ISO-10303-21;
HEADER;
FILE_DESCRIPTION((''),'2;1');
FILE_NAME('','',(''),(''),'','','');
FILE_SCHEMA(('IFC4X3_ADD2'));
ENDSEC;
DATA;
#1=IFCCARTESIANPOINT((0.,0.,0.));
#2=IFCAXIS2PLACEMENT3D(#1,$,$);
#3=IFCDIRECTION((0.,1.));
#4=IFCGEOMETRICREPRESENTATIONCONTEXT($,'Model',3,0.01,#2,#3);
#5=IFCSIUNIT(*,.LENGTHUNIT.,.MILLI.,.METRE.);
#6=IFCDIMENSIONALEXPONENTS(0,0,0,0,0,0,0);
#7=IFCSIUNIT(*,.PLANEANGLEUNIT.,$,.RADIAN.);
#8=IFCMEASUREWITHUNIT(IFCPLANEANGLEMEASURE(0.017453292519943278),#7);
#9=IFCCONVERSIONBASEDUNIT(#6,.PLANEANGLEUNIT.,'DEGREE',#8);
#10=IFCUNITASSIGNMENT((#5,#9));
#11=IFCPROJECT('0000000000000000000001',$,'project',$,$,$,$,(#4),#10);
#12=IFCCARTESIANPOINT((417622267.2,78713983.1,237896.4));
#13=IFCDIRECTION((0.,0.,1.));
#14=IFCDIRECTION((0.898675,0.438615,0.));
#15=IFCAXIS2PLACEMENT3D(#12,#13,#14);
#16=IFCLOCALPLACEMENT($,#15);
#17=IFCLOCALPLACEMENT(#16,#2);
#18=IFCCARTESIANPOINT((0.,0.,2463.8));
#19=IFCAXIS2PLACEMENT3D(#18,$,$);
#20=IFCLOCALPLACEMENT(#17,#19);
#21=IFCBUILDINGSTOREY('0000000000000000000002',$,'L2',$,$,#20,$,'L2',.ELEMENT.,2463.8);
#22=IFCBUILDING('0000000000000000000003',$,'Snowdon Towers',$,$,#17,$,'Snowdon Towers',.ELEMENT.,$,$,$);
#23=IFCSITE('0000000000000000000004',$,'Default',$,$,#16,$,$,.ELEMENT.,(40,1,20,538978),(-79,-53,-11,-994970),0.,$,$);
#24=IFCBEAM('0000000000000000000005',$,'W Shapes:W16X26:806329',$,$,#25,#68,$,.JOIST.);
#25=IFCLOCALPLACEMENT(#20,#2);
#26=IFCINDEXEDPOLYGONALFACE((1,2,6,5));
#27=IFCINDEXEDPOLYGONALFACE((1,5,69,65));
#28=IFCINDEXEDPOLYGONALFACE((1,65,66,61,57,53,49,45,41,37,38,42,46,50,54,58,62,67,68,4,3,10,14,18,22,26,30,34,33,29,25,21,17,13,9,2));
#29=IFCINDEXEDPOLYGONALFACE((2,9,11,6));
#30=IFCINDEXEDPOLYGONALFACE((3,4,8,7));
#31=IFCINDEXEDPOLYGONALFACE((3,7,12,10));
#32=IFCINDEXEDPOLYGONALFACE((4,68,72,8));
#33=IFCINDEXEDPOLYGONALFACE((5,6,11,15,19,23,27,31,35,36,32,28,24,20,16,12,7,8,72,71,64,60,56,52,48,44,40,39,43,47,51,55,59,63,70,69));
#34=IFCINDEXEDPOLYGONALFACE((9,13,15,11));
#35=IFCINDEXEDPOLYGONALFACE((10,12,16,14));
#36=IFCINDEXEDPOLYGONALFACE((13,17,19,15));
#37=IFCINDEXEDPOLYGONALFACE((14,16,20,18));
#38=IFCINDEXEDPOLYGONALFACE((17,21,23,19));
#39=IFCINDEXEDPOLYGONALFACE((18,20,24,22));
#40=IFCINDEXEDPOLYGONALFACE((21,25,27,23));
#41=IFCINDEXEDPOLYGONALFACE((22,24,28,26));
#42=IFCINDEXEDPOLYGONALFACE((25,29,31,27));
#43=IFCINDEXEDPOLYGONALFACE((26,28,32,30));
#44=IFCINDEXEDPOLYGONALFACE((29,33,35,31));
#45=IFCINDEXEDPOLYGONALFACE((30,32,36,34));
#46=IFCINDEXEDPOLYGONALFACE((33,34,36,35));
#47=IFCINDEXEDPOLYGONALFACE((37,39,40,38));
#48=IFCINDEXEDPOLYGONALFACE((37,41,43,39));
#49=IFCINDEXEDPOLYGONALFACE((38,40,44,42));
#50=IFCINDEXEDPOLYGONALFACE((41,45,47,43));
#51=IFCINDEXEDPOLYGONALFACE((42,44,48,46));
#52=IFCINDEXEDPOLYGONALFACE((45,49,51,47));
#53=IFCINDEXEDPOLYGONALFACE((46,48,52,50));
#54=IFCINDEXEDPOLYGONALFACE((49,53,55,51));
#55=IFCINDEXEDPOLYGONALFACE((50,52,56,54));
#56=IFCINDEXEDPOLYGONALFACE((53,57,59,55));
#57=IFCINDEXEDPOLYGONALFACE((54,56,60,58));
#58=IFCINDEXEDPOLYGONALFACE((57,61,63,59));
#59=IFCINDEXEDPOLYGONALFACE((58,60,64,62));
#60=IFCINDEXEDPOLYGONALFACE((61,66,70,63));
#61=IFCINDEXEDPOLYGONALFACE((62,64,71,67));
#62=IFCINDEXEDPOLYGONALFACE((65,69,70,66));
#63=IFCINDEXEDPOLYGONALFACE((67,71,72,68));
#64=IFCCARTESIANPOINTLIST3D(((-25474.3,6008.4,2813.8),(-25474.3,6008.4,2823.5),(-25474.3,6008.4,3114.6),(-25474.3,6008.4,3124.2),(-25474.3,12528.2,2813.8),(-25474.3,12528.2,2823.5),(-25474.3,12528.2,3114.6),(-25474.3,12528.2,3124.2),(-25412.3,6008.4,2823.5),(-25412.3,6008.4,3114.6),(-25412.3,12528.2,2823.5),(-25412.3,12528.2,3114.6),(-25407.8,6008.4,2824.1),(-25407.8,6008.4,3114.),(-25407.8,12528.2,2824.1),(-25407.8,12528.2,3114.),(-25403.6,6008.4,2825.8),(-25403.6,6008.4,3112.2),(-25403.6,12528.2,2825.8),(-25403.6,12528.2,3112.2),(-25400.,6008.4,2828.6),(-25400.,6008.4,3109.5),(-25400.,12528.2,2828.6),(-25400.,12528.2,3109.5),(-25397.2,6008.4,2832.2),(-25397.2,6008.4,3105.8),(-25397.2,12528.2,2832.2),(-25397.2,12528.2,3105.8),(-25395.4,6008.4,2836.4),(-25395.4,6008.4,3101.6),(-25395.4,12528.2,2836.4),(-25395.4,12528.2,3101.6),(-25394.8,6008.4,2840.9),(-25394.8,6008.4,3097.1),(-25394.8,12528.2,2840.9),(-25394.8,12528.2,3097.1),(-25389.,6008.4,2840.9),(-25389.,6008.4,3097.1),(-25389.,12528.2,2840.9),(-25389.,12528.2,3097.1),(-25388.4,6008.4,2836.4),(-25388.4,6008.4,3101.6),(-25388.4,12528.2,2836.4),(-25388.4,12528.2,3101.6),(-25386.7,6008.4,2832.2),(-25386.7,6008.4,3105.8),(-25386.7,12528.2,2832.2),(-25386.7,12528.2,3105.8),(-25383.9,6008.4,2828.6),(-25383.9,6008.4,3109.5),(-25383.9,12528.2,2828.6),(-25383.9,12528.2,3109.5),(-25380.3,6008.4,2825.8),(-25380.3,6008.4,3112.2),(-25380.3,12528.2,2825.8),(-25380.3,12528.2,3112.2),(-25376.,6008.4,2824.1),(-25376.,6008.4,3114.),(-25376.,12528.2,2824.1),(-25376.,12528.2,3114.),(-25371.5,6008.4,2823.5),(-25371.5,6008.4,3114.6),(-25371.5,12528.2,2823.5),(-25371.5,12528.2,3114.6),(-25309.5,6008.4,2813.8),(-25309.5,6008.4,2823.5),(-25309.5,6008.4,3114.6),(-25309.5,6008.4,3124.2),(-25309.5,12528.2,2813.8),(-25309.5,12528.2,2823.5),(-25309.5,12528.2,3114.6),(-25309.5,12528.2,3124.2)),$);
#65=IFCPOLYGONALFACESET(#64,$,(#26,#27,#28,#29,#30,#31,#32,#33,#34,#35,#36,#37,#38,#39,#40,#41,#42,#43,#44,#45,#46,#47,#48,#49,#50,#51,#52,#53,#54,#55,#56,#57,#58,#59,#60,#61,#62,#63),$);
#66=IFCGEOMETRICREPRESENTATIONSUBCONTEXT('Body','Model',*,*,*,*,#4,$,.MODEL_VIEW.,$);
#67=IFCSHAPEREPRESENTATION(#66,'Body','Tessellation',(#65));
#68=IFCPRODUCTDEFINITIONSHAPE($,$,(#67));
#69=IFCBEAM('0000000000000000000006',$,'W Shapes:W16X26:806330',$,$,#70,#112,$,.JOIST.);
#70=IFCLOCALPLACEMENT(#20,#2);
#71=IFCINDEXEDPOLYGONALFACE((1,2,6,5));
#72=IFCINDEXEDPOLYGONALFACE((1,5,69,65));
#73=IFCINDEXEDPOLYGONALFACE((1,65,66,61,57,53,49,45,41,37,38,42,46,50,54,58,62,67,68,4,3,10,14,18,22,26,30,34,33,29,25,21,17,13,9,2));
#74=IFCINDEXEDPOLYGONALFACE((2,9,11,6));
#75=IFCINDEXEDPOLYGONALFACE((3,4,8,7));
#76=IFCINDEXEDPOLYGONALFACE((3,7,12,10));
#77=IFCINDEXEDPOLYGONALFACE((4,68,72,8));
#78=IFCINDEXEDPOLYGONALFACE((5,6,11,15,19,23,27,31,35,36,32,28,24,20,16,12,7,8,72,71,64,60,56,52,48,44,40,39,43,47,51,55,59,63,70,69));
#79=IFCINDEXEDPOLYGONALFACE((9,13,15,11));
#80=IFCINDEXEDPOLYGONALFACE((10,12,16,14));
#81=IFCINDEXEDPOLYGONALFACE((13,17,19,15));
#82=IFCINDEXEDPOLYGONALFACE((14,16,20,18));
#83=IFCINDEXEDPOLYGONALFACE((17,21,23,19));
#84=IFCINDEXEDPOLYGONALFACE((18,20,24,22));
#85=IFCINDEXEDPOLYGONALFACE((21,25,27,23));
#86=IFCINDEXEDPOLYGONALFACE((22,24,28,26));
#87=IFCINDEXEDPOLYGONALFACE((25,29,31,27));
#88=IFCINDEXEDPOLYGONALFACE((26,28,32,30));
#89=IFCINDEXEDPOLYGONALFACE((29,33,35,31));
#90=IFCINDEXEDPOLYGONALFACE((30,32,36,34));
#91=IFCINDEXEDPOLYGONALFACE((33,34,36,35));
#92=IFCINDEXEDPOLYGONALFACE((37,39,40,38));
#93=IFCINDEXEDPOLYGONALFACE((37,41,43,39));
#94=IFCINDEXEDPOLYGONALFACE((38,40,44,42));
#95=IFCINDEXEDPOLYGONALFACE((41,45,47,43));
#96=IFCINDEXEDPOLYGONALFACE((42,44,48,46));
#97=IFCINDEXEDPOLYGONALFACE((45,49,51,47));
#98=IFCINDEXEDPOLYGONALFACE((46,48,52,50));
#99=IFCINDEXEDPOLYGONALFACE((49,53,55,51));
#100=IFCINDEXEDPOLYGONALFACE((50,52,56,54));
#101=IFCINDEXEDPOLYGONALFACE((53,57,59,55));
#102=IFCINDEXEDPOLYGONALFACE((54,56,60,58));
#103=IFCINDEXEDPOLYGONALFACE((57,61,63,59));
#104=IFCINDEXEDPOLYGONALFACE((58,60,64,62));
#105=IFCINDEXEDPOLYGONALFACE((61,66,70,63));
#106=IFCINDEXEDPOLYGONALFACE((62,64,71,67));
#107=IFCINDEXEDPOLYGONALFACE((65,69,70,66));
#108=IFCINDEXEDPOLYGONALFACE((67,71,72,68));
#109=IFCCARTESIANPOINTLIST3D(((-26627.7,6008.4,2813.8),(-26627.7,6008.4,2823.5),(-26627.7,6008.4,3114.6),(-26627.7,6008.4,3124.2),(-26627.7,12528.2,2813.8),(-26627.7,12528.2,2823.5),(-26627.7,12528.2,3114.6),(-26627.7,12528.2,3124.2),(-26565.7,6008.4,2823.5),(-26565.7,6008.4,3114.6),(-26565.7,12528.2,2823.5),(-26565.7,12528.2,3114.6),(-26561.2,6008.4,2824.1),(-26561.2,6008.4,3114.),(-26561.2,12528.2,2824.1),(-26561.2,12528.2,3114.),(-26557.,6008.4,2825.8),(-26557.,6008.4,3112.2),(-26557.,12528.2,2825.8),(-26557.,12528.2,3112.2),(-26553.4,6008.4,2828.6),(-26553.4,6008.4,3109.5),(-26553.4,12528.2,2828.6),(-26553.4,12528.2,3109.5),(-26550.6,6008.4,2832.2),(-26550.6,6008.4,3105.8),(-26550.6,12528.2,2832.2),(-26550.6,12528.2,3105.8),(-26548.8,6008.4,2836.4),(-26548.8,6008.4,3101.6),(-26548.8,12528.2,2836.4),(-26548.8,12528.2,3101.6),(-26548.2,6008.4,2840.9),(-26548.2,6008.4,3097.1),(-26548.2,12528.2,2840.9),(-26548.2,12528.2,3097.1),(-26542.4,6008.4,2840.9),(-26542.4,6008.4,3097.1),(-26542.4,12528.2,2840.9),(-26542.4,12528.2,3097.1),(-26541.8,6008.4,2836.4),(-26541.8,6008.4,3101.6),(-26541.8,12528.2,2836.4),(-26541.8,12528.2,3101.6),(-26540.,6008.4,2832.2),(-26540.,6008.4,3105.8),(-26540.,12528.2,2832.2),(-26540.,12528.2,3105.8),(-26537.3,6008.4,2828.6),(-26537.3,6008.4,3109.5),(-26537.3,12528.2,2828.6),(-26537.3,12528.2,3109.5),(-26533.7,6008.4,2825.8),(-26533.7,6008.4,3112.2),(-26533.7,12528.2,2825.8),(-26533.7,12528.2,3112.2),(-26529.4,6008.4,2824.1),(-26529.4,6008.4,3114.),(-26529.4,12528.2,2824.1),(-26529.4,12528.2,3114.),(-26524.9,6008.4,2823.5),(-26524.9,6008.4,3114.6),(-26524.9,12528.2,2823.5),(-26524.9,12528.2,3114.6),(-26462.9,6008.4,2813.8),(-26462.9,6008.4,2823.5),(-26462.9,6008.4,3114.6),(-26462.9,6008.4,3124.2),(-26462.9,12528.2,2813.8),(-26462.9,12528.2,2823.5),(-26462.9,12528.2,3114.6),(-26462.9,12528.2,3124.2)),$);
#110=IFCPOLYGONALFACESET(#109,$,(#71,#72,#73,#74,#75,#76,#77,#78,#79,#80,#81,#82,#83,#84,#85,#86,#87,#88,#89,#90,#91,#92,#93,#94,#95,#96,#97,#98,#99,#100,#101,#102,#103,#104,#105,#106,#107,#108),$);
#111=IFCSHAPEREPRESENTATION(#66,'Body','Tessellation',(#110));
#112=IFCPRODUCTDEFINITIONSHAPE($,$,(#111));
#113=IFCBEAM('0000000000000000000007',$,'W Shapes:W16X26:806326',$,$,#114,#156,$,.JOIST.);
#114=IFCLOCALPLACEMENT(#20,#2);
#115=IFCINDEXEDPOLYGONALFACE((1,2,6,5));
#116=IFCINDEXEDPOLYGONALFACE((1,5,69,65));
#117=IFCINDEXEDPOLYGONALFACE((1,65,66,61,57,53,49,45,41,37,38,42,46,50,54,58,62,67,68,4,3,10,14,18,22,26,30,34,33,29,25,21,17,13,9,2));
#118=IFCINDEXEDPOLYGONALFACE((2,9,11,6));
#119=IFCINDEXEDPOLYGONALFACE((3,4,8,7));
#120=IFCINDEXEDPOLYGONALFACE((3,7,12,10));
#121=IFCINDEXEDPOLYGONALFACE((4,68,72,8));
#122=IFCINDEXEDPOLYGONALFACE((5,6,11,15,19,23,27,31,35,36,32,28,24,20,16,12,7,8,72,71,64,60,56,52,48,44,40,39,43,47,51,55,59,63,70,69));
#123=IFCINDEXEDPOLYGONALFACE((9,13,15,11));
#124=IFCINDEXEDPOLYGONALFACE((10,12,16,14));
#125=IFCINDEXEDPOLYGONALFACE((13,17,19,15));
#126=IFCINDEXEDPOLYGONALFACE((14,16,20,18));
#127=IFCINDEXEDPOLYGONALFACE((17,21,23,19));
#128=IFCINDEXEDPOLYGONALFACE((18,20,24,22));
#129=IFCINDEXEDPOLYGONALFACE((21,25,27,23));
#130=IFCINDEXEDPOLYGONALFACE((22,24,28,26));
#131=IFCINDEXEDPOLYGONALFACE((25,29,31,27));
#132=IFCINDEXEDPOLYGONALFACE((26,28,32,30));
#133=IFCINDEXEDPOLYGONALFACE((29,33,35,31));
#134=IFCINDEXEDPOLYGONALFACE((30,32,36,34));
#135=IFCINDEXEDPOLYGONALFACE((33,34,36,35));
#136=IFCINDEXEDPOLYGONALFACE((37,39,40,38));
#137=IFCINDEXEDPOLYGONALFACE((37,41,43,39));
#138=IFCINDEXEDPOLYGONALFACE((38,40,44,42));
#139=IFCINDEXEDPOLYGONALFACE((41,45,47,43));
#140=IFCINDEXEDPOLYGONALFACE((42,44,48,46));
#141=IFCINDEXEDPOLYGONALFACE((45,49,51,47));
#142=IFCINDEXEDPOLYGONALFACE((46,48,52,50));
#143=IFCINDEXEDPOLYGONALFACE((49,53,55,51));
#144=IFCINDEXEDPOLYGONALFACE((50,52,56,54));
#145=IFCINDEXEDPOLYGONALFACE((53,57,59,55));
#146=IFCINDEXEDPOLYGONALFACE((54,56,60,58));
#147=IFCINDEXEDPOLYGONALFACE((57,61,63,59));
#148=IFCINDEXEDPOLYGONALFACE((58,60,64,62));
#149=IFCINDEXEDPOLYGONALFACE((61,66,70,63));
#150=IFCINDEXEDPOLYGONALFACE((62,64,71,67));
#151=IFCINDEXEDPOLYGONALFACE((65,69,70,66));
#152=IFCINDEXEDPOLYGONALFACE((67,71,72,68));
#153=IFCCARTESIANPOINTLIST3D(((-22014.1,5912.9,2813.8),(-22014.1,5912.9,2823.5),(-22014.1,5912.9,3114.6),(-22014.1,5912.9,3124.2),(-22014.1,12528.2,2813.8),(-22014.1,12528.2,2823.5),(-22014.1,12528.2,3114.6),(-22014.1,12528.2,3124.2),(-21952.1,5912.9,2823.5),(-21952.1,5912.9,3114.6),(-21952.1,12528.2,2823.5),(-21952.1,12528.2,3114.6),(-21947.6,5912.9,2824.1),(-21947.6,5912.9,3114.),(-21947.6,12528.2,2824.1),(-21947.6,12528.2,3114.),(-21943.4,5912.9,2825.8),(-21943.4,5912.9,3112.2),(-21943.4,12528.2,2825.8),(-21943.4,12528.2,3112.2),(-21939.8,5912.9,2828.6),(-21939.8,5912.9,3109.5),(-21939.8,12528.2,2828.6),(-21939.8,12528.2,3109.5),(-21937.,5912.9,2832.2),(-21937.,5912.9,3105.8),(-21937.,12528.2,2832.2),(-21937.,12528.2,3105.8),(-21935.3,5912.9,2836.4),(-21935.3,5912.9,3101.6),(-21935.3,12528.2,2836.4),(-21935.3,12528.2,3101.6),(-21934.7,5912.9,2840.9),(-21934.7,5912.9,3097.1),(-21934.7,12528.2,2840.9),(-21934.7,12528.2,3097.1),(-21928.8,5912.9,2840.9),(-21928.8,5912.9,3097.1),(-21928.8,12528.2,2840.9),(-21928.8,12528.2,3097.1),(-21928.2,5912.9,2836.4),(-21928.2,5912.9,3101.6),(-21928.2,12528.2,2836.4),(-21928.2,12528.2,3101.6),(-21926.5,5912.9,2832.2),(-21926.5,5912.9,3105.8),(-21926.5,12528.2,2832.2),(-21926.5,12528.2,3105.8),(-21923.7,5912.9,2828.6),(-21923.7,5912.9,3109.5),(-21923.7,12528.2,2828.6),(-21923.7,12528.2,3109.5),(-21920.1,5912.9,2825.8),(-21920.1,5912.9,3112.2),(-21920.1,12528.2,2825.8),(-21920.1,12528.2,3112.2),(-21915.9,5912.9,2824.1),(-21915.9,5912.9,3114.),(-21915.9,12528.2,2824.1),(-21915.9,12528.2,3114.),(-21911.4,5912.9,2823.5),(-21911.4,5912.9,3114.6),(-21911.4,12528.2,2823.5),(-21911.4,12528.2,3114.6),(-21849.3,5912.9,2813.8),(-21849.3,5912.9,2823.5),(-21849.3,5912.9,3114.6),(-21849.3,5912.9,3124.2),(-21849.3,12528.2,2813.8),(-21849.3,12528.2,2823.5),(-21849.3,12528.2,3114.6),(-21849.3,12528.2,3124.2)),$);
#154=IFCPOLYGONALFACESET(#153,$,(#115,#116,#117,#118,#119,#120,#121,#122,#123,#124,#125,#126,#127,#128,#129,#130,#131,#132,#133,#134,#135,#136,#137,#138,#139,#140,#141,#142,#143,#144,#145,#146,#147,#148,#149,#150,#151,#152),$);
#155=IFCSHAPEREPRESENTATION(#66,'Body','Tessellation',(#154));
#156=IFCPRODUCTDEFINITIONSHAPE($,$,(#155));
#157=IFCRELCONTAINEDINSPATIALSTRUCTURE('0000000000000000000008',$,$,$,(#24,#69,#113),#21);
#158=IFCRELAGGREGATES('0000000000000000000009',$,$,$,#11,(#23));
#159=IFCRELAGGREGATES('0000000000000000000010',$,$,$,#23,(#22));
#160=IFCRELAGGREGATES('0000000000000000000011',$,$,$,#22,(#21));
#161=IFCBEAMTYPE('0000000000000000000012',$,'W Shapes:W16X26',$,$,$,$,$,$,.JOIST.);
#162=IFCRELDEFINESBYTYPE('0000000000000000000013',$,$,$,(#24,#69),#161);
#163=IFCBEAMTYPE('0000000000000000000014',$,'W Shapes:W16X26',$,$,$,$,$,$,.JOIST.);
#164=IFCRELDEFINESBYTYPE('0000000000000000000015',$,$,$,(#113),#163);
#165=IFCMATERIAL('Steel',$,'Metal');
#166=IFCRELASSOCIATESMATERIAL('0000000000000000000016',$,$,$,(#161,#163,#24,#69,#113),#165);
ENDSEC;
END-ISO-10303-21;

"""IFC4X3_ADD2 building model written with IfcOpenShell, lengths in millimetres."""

from ifc_helpers import new_model, entity, si_unit, converted_unit, direction, frame, frame_2d, origin, place, context, subcontext, project, spatial, polyline, circle_curve, parameter, trimmed, segment, composite_curve, outline, extrude, source, transform, mapped, material, material_profile, profile_set, profile_usage, type_object, type_shapes, element, save


model = new_model("IFC4X3_ADD2")

# Units and contexts
model_context = context("Model", 3, precision=0.01, world=origin(), true_north=direction((0.0, 1.0)))
body_context = subcontext(model_context, "Body", "Model", "MODEL_VIEW")
ifc_project = project(units=[si_unit("LENGTHUNIT", "METRE", prefix="MILLI"), converted_unit("PLANEANGLEUNIT", "DEGREE", entity("IfcPlaneAngleMeasure", 0.017453292519943278), si_unit("PLANEANGLEUNIT", "RADIAN"), dimensions=[0, 0, 0, 0, 0, 0, 0])], contexts=[model_context])

# Site, building, storey
site_placement = place(None, frame((417622267.2, 78713983.1, 237896.4), z_axis=(0.0, 0.0, 1.0), x_axis=(0.898675, 0.438615, 0.0)))
site = spatial("IfcSite", under=ifc_project, at=site_placement, Name="Default", CompositionType="ELEMENT", RefLatitude=(40, 1, 20, 538978), RefLongitude=(-79, -53, -11, -994970), RefElevation=0.0)
building_placement = place(site_placement, origin())
building = spatial("IfcBuilding", under=site, at=building_placement, Name="Snowdon Towers", LongName="Snowdon Towers", CompositionType="ELEMENT")
storey_placement = place(building_placement, frame((0.0, 0.0, 2463.8)))
storey = spatial("IfcBuildingStorey", under=building, at=storey_placement, Name="L2", LongName="L2", CompositionType="ELEMENT", Elevation=2463.8)

# Beams
ifc_material_1 = material(Name="Steel", Category="Metal")
ifc_material_profile_1 = material_profile(ifc_material_1, outline(composite_curve([segment(polyline([(-82.4, -145.6), (-82.4, -155.2)]), True, "CONTINUOUS"), segment(polyline([(-82.4, -155.2), (82.4, -155.2)]), True, "CONTINUOUS"), segment(polyline([(82.4, -155.2), (82.4, -145.6)]), True, "CONTINUOUS"), segment(polyline([(82.4, -145.6), (20.4, -145.6)]), True, "CONTINUOUS"), segment(trimmed(circle_curve(frame_2d((20.4, -128.1), x_axis=(1.0, 0.0)), 17.5), [parameter(180.0)], [parameter(270.0)], True, "PARAMETER"), False, "CONTINUOUS"), segment(polyline([(2.9, -128.1), (2.9, 128.1)]), True, "CONTINUOUS"), segment(trimmed(circle_curve(frame_2d((20.4, 128.1), x_axis=(1.0, 0.0)), 17.5), [parameter(90.0)], [parameter(180.0)], True, "PARAMETER"), False, "CONTINUOUS"), segment(polyline([(20.4, 145.6), (82.4, 145.6)]), True, "CONTINUOUS"), segment(polyline([(82.4, 145.6), (82.4, 155.2)]), True, "CONTINUOUS"), segment(polyline([(82.4, 155.2), (-82.4, 155.2)]), True, "CONTINUOUS"), segment(polyline([(-82.4, 155.2), (-82.4, 145.6)]), True, "CONTINUOUS"), segment(polyline([(-82.4, 145.6), (-20.4, 145.6)]), True, "CONTINUOUS"), segment(trimmed(circle_curve(frame_2d((-20.4, 128.1), x_axis=(1.0, 0.0)), 17.5), [parameter(360.0)], [parameter(90.0)], True, "PARAMETER"), False, "CONTINUOUS"), segment(polyline([(-2.9, 128.1), (-2.9, -128.1)]), True, "CONTINUOUS"), segment(trimmed(circle_curve(frame_2d((-20.4, -128.1), x_axis=(1.0, 0.0)), 17.5), [parameter(270.0)], [parameter(360.0)], True, "PARAMETER"), False, "CONTINUOUS"), segment(polyline([(-20.4, -145.6), (-82.4, -145.6)]), True, "CONTINUOUS")], self_intersect=False)), Name="W16X26")
ifc_profile_set_1 = profile_set([ifc_material_profile_1], Name="W16X26")
ifc_profile_usage_1 = profile_usage(ifc_profile_set_1, cardinal=8)
beam_type_1 = type_object("IfcBeamType", Name="W Shapes:W16X26", PredefinedType="JOIST", material=ifc_profile_set_1)
shared_shape_1 = source(origin(), body_context, "Body", "SweptSolid", [
    extrude(outline(composite_curve([segment(polyline([(-82.4, -145.6), (-82.4, -155.2)]), True, "CONTINUOUS"), segment(polyline([(-82.4, -155.2), (82.4, -155.2)]), True, "CONTINUOUS"), segment(polyline([(82.4, -155.2), (82.4, -145.6)]), True, "CONTINUOUS"), segment(polyline([(82.4, -145.6), (20.4, -145.6)]), True, "CONTINUOUS"), segment(trimmed(circle_curve(frame_2d((20.4, -128.1), x_axis=(1.0, 0.0)), 17.5), [parameter(180.0)], [parameter(270.0)], True, "PARAMETER"), False, "CONTINUOUS"), segment(polyline([(2.9, -128.1), (2.9, 128.1)]), True, "CONTINUOUS"), segment(trimmed(circle_curve(frame_2d((20.4, 128.1), x_axis=(1.0, 0.0)), 17.5), [parameter(90.0)], [parameter(180.0)], True, "PARAMETER"), False, "CONTINUOUS"), segment(polyline([(20.4, 145.6), (82.4, 145.6)]), True, "CONTINUOUS"), segment(polyline([(82.4, 145.6), (82.4, 155.2)]), True, "CONTINUOUS"), segment(polyline([(82.4, 155.2), (-82.4, 155.2)]), True, "CONTINUOUS"), segment(polyline([(-82.4, 155.2), (-82.4, 145.6)]), True, "CONTINUOUS"), segment(polyline([(-82.4, 145.6), (-20.4, 145.6)]), True, "CONTINUOUS"), segment(trimmed(circle_curve(frame_2d((-20.4, 128.1), x_axis=(1.0, 0.0)), 17.5), [parameter(360.0)], [parameter(90.0)], True, "PARAMETER"), False, "CONTINUOUS"), segment(polyline([(-2.9, 128.1), (-2.9, -128.1)]), True, "CONTINUOUS"), segment(trimmed(circle_curve(frame_2d((-20.4, -128.1), x_axis=(1.0, 0.0)), 17.5), [parameter(270.0)], [parameter(360.0)], True, "PARAMETER"), False, "CONTINUOUS"), segment(polyline([(-20.4, -145.6), (-82.4, -145.6)]), True, "CONTINUOUS")], self_intersect=False)), frame((-3282.6, 0.0, 0.0), z_axis=(-1.0, 0.0, 0.0), x_axis=(0.0, -1.0, 0.0)), (0.0, 0.0, -1.0), 6519.8),
])
type_shapes(beam_type_1, [shared_shape_1])
for number, where, z_axis, x_axis, name in (
    (1, (-25391.9, 9245.6, 2969.0), (0.0, 0.0, 1.0), (0.0, -1.0, 0.0), "W Shapes:W16X26:806329"),
    (2, (-26545.3, 9245.6, 2969.0), (0.0, 0.0, 1.0), (0.0, -1.0, 0.0), "W Shapes:W16X26:806330"),
):
    element("IfcBeam", number, at=place(storey_placement, frame(where, z_axis=z_axis, x_axis=x_axis)), inside=storey, type_object=beam_type_1, material=ifc_profile_usage_1, Name=name, PredefinedType="JOIST", context=body_context, shape_type="MappedRepresentation", body=[
        mapped(shared_shape_1, transform((0.0, 0.0, 0.0), scale=1.0)),
    ])
beam_type_2 = type_object("IfcBeamType", Name="W Shapes:W16X26", PredefinedType="JOIST", material=ifc_profile_set_1)
shared_shape_2 = source(origin(), body_context, "Body", "SweptSolid", [
    extrude(outline(composite_curve([segment(polyline([(-82.4, -145.6), (-82.4, -155.2)]), True, "CONTINUOUS"), segment(polyline([(-82.4, -155.2), (82.4, -155.2)]), True, "CONTINUOUS"), segment(polyline([(82.4, -155.2), (82.4, -145.6)]), True, "CONTINUOUS"), segment(polyline([(82.4, -145.6), (20.4, -145.6)]), True, "CONTINUOUS"), segment(trimmed(circle_curve(frame_2d((20.4, -128.1), x_axis=(1.0, 0.0)), 17.5), [parameter(180.0)], [parameter(270.0)], True, "PARAMETER"), False, "CONTINUOUS"), segment(polyline([(2.9, -128.1), (2.9, 128.1)]), True, "CONTINUOUS"), segment(trimmed(circle_curve(frame_2d((20.4, 128.1), x_axis=(1.0, 0.0)), 17.5), [parameter(90.0)], [parameter(180.0)], True, "PARAMETER"), False, "CONTINUOUS"), segment(polyline([(20.4, 145.6), (82.4, 145.6)]), True, "CONTINUOUS"), segment(polyline([(82.4, 145.6), (82.4, 155.2)]), True, "CONTINUOUS"), segment(polyline([(82.4, 155.2), (-82.4, 155.2)]), True, "CONTINUOUS"), segment(polyline([(-82.4, 155.2), (-82.4, 145.6)]), True, "CONTINUOUS"), segment(polyline([(-82.4, 145.6), (-20.4, 145.6)]), True, "CONTINUOUS"), segment(trimmed(circle_curve(frame_2d((-20.4, 128.1), x_axis=(1.0, 0.0)), 17.5), [parameter(360.0)], [parameter(90.0)], True, "PARAMETER"), False, "CONTINUOUS"), segment(polyline([(-2.9, 128.1), (-2.9, -128.1)]), True, "CONTINUOUS"), segment(trimmed(circle_curve(frame_2d((-20.4, -128.1), x_axis=(1.0, 0.0)), 17.5), [parameter(270.0)], [parameter(360.0)], True, "PARAMETER"), False, "CONTINUOUS"), segment(polyline([(-20.4, -145.6), (-82.4, -145.6)]), True, "CONTINUOUS")], self_intersect=False)), frame((-3282.6, 0.0, 0.0), z_axis=(-1.0, 0.0, 0.0), x_axis=(0.0, -1.0, 0.0)), (0.0, 0.0, -1.0), 6615.2),
])
type_shapes(beam_type_2, [shared_shape_2])
beam_1_placement = place(storey_placement, frame((-21931.7, 9245.6, 2969.0), z_axis=(0.0, 0.0, 1.0), x_axis=(0.0, -1.0, 0.0)))
element("IfcBeam", 3, at=beam_1_placement, inside=storey, type_object=beam_type_2, material=ifc_profile_usage_1, Name="W Shapes:W16X26:806326", PredefinedType="JOIST", context=body_context, shape_type="MappedRepresentation", body=[
    mapped(shared_shape_2, transform((0.0, 0.0, 0.0), scale=1.0)),
])

save(model, "model.ifc")
